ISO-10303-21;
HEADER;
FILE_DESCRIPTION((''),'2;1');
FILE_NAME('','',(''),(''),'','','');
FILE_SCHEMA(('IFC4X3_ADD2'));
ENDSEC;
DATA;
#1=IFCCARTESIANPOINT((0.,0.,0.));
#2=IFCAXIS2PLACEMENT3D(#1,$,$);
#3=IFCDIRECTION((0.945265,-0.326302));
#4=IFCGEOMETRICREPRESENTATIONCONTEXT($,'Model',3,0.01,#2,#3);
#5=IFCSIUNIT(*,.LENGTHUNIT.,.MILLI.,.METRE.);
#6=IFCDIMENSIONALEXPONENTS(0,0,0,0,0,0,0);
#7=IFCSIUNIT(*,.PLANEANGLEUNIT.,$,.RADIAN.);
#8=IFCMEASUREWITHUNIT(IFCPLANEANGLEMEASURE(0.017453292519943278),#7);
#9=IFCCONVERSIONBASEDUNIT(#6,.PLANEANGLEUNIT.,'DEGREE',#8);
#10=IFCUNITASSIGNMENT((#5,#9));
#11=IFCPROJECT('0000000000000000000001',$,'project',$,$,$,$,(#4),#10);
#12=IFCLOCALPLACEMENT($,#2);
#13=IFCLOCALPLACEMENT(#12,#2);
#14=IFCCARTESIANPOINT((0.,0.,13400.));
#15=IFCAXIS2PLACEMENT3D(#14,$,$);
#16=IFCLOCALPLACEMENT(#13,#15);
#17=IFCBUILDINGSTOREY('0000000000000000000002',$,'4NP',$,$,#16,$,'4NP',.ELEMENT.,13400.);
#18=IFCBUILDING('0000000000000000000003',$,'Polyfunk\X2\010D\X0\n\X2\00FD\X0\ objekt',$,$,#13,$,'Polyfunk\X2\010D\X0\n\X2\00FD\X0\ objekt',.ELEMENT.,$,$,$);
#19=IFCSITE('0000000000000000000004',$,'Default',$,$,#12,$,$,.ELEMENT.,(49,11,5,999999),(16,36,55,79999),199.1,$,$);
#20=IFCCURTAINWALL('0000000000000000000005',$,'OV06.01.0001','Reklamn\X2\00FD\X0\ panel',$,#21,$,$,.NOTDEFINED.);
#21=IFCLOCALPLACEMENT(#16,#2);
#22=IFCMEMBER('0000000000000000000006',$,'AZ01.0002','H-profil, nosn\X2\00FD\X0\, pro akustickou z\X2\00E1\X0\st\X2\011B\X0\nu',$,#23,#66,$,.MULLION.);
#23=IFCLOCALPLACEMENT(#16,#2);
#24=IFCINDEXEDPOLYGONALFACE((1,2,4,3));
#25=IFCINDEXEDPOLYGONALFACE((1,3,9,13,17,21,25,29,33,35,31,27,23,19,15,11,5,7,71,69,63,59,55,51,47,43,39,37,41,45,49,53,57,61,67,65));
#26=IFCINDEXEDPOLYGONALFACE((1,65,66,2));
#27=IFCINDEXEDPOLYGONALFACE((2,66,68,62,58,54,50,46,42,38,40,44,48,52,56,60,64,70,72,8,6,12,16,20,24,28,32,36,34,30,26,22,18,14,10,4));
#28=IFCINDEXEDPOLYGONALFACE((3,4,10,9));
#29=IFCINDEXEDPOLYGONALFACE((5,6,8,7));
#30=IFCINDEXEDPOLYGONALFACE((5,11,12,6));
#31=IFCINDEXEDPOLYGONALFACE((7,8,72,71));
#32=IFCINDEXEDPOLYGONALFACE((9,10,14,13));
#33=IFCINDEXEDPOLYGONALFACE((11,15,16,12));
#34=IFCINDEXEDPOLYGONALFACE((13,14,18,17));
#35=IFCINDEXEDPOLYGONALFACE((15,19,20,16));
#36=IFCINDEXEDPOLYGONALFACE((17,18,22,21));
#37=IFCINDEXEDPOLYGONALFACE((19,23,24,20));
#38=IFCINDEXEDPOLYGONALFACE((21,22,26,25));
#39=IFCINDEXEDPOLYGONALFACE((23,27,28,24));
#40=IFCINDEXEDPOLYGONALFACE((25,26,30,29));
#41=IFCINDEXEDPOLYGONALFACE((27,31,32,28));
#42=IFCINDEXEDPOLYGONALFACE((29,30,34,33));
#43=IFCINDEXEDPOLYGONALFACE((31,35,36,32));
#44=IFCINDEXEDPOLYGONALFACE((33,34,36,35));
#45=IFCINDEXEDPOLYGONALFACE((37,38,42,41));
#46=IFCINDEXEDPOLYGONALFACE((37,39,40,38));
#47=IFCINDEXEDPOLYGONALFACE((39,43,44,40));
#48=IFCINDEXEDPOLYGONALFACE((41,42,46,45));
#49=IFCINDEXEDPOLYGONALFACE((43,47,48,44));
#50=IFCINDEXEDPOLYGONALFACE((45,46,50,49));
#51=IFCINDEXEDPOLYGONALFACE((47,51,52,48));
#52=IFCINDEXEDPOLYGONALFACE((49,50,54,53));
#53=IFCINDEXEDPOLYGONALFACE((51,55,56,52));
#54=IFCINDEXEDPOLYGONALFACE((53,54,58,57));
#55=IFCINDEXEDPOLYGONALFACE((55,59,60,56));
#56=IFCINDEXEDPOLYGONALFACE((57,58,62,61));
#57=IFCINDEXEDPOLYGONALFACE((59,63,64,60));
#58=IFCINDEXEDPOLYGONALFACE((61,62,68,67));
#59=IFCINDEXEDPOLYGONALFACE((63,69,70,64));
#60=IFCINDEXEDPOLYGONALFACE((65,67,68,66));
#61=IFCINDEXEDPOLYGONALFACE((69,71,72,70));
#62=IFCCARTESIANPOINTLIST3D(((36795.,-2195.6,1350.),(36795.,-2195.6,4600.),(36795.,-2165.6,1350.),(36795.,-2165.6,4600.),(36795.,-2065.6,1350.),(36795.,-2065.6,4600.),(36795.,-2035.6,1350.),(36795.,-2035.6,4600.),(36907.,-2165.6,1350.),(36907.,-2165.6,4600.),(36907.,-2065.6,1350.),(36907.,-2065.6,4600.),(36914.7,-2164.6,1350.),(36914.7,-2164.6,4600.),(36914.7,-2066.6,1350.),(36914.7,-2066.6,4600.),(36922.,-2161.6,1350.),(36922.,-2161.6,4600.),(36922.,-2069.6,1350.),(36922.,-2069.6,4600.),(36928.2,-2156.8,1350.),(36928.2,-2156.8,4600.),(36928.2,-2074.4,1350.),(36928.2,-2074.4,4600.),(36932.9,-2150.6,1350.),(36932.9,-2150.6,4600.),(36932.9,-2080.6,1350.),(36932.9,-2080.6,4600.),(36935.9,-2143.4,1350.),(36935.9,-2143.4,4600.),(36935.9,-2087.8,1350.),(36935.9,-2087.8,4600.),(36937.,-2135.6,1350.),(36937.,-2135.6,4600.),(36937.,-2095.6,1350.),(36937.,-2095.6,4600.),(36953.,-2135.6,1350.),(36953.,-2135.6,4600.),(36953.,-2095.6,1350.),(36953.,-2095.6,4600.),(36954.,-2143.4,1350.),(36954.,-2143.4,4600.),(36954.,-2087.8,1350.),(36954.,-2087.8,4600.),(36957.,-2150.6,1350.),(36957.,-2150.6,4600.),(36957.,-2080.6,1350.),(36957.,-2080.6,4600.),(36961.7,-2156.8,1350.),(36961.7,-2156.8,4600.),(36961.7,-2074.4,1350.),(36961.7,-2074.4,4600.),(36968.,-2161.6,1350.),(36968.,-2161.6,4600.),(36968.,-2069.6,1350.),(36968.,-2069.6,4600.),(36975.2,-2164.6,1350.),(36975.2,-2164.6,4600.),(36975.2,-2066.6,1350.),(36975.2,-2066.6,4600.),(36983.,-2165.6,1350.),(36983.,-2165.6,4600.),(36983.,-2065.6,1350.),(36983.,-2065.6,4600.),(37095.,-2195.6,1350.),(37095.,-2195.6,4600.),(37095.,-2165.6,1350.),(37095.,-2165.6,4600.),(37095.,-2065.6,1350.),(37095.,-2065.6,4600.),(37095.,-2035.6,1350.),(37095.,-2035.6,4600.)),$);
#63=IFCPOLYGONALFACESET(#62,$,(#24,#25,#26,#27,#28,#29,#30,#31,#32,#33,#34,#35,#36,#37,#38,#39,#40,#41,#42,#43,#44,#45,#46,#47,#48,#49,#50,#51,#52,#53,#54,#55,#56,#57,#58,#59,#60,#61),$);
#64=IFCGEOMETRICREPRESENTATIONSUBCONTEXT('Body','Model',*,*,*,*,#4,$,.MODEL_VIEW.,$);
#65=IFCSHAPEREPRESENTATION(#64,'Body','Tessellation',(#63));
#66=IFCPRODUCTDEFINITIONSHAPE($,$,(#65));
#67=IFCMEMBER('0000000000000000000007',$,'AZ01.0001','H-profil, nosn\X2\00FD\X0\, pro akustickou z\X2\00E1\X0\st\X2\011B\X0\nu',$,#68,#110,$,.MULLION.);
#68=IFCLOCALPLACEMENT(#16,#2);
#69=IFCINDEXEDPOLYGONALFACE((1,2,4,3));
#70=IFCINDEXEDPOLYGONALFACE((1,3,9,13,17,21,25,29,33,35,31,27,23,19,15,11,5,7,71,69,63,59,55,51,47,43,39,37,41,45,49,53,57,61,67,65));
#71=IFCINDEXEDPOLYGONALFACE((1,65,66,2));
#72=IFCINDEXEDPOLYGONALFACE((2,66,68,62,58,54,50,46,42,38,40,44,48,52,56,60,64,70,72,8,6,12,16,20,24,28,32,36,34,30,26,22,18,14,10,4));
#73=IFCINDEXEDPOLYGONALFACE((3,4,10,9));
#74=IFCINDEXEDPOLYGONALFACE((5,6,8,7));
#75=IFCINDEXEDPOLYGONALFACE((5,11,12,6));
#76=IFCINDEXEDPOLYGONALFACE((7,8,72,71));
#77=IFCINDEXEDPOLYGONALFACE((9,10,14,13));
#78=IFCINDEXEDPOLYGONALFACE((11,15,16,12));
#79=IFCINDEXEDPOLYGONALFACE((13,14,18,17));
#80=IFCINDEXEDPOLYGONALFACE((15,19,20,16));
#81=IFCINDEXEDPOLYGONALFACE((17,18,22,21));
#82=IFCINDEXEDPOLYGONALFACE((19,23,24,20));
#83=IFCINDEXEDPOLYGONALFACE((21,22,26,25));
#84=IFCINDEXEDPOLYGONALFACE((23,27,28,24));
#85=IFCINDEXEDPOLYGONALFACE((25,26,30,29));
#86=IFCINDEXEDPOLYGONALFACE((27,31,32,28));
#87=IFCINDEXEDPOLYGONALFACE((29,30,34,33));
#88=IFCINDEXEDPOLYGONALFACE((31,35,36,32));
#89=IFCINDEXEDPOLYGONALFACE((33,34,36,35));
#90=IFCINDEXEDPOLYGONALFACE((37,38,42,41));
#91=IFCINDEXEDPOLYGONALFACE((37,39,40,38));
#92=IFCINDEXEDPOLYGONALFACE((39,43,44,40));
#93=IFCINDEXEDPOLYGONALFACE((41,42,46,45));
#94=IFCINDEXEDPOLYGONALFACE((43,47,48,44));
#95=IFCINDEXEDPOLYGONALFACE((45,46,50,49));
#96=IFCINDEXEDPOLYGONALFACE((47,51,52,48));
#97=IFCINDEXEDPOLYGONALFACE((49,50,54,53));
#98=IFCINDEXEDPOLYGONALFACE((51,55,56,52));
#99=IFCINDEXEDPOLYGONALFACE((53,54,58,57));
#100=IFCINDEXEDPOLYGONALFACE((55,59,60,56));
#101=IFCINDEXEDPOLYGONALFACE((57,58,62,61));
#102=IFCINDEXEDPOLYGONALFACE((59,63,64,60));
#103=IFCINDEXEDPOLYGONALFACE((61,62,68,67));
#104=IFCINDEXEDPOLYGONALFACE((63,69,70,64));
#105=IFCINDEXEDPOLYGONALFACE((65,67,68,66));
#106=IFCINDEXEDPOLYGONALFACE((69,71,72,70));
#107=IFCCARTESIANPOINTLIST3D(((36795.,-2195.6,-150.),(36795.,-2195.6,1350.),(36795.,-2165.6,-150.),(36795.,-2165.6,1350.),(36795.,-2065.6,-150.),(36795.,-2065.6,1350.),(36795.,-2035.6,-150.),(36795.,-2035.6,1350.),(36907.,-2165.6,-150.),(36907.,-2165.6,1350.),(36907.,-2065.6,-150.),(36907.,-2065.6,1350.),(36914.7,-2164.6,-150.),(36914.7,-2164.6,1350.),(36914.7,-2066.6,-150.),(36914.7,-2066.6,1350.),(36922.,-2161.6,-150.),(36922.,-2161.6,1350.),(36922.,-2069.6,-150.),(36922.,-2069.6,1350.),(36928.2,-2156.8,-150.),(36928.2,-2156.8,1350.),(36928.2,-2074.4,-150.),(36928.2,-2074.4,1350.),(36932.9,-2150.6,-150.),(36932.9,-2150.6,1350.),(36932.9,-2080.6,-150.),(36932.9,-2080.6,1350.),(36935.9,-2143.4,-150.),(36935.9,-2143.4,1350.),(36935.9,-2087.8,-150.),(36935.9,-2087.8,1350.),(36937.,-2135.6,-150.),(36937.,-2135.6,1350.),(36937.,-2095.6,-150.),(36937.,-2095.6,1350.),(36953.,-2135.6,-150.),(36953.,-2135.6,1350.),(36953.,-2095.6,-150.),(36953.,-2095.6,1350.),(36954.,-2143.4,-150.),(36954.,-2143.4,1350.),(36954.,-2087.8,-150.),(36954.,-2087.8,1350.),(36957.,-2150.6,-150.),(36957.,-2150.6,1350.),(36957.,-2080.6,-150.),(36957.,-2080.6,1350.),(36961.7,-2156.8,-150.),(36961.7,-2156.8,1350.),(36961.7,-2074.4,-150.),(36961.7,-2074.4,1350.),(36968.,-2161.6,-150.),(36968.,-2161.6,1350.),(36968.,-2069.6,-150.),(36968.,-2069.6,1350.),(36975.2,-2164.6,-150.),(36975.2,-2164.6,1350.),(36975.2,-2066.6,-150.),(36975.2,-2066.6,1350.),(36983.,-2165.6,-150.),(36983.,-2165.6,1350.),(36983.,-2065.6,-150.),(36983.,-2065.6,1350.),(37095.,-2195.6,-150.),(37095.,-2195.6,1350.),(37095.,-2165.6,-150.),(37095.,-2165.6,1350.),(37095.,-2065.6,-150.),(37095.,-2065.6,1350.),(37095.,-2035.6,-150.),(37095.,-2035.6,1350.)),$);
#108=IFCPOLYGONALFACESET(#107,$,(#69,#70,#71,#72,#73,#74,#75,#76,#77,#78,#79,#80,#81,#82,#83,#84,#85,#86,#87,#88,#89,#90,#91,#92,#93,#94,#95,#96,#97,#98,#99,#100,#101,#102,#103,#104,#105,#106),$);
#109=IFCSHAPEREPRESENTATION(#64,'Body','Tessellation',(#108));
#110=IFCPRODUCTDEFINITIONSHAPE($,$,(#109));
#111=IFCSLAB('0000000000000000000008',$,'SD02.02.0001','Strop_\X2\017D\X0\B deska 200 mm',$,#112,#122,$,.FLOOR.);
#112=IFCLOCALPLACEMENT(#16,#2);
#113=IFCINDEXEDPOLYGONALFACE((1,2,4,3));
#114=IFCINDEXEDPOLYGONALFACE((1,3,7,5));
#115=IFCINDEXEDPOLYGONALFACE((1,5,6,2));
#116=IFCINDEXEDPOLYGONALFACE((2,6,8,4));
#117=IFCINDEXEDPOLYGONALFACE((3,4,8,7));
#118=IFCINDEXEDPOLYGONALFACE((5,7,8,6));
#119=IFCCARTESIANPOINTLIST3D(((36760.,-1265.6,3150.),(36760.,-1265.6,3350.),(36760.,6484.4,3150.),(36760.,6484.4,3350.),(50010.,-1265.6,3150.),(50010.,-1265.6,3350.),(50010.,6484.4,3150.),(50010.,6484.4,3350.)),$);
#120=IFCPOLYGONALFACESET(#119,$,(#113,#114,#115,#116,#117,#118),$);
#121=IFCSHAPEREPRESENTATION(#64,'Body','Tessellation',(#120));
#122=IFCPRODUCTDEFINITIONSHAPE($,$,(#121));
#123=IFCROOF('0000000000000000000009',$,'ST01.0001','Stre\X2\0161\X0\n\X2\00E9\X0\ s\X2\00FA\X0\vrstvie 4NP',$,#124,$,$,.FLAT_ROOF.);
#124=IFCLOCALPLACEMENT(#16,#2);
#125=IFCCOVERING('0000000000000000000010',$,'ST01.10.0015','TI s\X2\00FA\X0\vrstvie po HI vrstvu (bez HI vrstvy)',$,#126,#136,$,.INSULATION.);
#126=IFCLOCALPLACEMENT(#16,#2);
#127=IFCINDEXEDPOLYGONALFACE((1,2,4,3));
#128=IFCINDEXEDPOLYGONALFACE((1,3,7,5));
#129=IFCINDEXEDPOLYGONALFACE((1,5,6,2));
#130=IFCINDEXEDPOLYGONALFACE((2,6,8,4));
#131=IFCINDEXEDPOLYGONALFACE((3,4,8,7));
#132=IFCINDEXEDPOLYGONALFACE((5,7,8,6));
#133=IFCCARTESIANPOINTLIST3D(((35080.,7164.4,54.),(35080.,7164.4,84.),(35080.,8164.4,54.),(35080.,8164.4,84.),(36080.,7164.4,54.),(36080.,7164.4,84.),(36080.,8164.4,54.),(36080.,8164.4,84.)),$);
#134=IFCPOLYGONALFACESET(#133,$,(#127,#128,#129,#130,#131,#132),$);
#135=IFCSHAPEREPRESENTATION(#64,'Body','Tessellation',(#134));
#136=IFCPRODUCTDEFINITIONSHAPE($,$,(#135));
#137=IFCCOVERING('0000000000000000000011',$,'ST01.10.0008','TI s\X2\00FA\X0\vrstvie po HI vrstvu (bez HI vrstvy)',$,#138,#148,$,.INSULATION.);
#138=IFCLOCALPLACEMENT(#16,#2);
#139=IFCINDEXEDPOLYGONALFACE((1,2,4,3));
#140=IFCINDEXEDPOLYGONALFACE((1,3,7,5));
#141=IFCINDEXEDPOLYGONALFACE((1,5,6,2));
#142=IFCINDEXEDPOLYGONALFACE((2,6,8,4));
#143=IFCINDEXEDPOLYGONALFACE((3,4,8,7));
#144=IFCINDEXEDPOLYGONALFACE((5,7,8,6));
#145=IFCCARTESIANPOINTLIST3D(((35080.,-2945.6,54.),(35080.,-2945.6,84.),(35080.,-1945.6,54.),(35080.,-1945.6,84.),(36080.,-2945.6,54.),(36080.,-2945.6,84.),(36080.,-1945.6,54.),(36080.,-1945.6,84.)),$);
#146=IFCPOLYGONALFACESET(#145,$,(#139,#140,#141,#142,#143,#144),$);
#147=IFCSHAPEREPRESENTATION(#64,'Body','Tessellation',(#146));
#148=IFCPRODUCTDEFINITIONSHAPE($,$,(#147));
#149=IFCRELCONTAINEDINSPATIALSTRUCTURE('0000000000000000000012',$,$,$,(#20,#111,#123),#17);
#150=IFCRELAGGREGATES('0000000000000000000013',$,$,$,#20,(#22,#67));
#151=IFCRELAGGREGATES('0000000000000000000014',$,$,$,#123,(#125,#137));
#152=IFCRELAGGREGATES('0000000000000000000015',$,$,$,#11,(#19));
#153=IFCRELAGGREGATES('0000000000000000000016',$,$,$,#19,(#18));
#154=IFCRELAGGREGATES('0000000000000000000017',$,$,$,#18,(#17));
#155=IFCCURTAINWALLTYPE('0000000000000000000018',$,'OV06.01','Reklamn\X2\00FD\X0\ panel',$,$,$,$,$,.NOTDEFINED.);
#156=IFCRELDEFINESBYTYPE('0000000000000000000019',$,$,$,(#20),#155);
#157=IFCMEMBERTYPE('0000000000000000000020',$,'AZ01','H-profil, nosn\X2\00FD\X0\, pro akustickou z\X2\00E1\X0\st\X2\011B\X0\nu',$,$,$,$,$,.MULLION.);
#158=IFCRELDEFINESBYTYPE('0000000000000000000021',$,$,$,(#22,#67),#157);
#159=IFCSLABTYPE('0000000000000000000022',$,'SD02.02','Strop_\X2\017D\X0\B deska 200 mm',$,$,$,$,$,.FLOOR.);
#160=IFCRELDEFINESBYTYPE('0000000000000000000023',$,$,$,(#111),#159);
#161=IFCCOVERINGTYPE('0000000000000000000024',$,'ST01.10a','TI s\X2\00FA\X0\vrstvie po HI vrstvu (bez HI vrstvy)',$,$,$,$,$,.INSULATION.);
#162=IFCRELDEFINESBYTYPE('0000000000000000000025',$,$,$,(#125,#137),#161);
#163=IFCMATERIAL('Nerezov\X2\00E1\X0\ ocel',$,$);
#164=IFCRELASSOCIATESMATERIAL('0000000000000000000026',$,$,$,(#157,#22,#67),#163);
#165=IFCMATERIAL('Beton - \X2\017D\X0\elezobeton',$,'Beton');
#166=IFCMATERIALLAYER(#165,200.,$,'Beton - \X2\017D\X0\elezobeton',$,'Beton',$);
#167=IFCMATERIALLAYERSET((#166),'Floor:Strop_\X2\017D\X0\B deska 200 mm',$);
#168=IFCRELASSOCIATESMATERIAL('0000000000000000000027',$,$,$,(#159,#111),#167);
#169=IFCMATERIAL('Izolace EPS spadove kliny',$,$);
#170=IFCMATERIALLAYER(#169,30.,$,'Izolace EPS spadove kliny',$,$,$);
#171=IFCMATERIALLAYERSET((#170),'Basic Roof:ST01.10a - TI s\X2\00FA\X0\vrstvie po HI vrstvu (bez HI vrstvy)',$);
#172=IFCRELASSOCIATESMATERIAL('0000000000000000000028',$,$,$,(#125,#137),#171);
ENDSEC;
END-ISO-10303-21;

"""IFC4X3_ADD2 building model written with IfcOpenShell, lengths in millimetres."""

from ifc_helpers import new_model, entity, si_unit, converted_unit, direction, frame, frame_2d, origin, place, context, subcontext, project, spatial, polyline, circle_curve, parameter, trimmed, segment, composite_curve, rectangle, outline, extrude, source, transform, mapped, material, layer, layer_set, layer_usage, material_profile, profile_set, profile_usage, type_object, type_shapes, element, aggregate, save


model = new_model("IFC4X3_ADD2")

# Units and contexts
model_context = context("Model", 3, precision=0.01, world=origin(), true_north=direction((0.945265, -0.326302)))
body_context = subcontext(model_context, "Body", "Model", "MODEL_VIEW")
ifc_project = project(units=[si_unit("LENGTHUNIT", "METRE", prefix="MILLI"), converted_unit("PLANEANGLEUNIT", "DEGREE", entity("IfcPlaneAngleMeasure", 0.017453292519943278), si_unit("PLANEANGLEUNIT", "RADIAN"), dimensions=[0, 0, 0, 0, 0, 0, 0])], contexts=[model_context])

# Site, building, storey
site_placement = place(None, origin())
site = spatial("IfcSite", under=ifc_project, at=site_placement, Name="Default", CompositionType="ELEMENT", RefLatitude=(49, 11, 5, 999999), RefLongitude=(16, 36, 55, 79999), RefElevation=199.1)
building_placement = place(site_placement, origin())
building = spatial("IfcBuilding", under=site, at=building_placement, Name="Polyfunkčný objekt", LongName="Polyfunkčný objekt", CompositionType="ELEMENT")
storey_placement = place(building_placement, frame((0.0, 0.0, 13400.0)))
storey = spatial("IfcBuildingStorey", under=building, at=storey_placement, Name="4NP", LongName="4NP", CompositionType="ELEMENT", Elevation=13400.0)

# Curtain wall, members
curtain_wall_type = type_object("IfcCurtainWallType", Name="OV06.01", Description="Reklamný panel", PredefinedType="NOTDEFINED")
curtain_wall_placement = place(storey_placement, frame((0.0, 0.0, -13400.0)))
curtain_wall = element("IfcCurtainWall", 1, at=curtain_wall_placement, inside=storey, type_object=curtain_wall_type, Name="OV06.01.0001", Description="Reklamný panel", PredefinedType="NOTDEFINED")
ifc_material_1 = material(Name="Nerezová ocel")
ifc_material_profile = material_profile(ifc_material_1, outline(composite_curve([segment(polyline([(50.0, -150.0), (80.0, -150.0)]), True, "CONTINUOUS"), segment(polyline([(80.0, -150.0), (80.0, 150.0)]), True, "CONTINUOUS"), segment(polyline([(80.0, 150.0), (50.0, 150.0)]), True, "CONTINUOUS"), segment(polyline([(50.0, 150.0), (50.0, 38.0)]), True, "CONTINUOUS"), segment(trimmed(circle_curve(frame_2d((20.0, 38.0), x_axis=(0.0, 1.0)), 30.0), [parameter(180.0)], [parameter(270.0)], True, "PARAMETER"), False, "CONTINUOUS"), segment(polyline([(20.0, 8.0), (-20.0, 8.0)]), True, "CONTINUOUS"), segment(trimmed(circle_curve(frame_2d((-20.0, 38.0), x_axis=(0.0, 1.0)), 30.0), [parameter(90.0)], [parameter(180.0)], True, "PARAMETER"), False, "CONTINUOUS"), segment(polyline([(-50.0, 38.0), (-50.0, 150.0)]), True, "CONTINUOUS"), segment(polyline([(-50.0, 150.0), (-80.0, 150.0)]), True, "CONTINUOUS"), segment(polyline([(-80.0, 150.0), (-80.0, -150.0)]), True, "CONTINUOUS"), segment(polyline([(-80.0, -150.0), (-50.0, -150.0)]), True, "CONTINUOUS"), segment(polyline([(-50.0, -150.0), (-50.0, -38.0)]), True, "CONTINUOUS"), segment(trimmed(circle_curve(frame_2d((-20.0, -38.0), x_axis=(0.0, 1.0)), 30.0), [parameter(0.0)], [parameter(90.0)], True, "PARAMETER"), False, "CONTINUOUS"), segment(polyline([(-20.0, -8.0), (20.0, -8.0)]), True, "CONTINUOUS"), segment(trimmed(circle_curve(frame_2d((20.0, -38.0), x_axis=(0.0, 1.0)), 30.0), [parameter(270.0)], [parameter(0.0)], True, "PARAMETER"), False, "CONTINUOUS"), segment(polyline([(50.0, -38.0), (50.0, -150.0)]), True, "CONTINUOUS")], self_intersect=False)), Name="Profil zástena")
ifc_profile_set = profile_set([ifc_material_profile], Name="Profil zástena")
ifc_profile_usage = profile_usage(ifc_profile_set)
member_type = type_object("IfcMemberType", Name="AZ01", Description="H-profil, nosný, pro akustickou zástěnu", PredefinedType="MULLION", material=ifc_profile_set)
shared_shape_1 = source(origin(), body_context, "Body", "SweptSolid", [
    extrude(outline(composite_curve([segment(polyline([(50.0, -150.0), (80.0, -150.0)]), True, "CONTINUOUS"), segment(polyline([(80.0, -150.0), (80.0, 150.0)]), True, "CONTINUOUS"), segment(polyline([(80.0, 150.0), (50.0, 150.0)]), True, "CONTINUOUS"), segment(polyline([(50.0, 150.0), (50.0, 38.0)]), True, "CONTINUOUS"), segment(trimmed(circle_curve(frame_2d((20.0, 38.0), x_axis=(0.0, 1.0)), 30.0), [parameter(180.0)], [parameter(270.0)], True, "PARAMETER"), False, "CONTINUOUS"), segment(polyline([(20.0, 8.0), (-20.0, 8.0)]), True, "CONTINUOUS"), segment(trimmed(circle_curve(frame_2d((-20.0, 38.0), x_axis=(0.0, 1.0)), 30.0), [parameter(90.0)], [parameter(180.0)], True, "PARAMETER"), False, "CONTINUOUS"), segment(polyline([(-50.0, 38.0), (-50.0, 150.0)]), True, "CONTINUOUS"), segment(polyline([(-50.0, 150.0), (-80.0, 150.0)]), True, "CONTINUOUS"), segment(polyline([(-80.0, 150.0), (-80.0, -150.0)]), True, "CONTINUOUS"), segment(polyline([(-80.0, -150.0), (-50.0, -150.0)]), True, "CONTINUOUS"), segment(polyline([(-50.0, -150.0), (-50.0, -38.0)]), True, "CONTINUOUS"), segment(trimmed(circle_curve(frame_2d((-20.0, -38.0), x_axis=(0.0, 1.0)), 30.0), [parameter(0.0)], [parameter(90.0)], True, "PARAMETER"), False, "CONTINUOUS"), segment(polyline([(-20.0, -8.0), (20.0, -8.0)]), True, "CONTINUOUS"), segment(trimmed(circle_curve(frame_2d((20.0, -38.0), x_axis=(0.0, 1.0)), 30.0), [parameter(270.0)], [parameter(0.0)], True, "PARAMETER"), False, "CONTINUOUS"), segment(polyline([(50.0, -38.0), (50.0, -150.0)]), True, "CONTINUOUS")], self_intersect=False)), frame((-150.0, 0.0, -3250.0), z_axis=(0.0, 0.0, 1.0), x_axis=(0.0, 1.0, 0.0)), (0.0, 0.0, 1.0), 3250.0),
])
member_1_placement = place(curtain_wall_placement, frame((36795.0, -2115.6, 18000.0), z_axis=(0.0, 0.0, 1.0), x_axis=(-1.0, 0.0, 0.0)))
member_1 = element("IfcMember", 2, at=member_1_placement, type_object=member_type, material=ifc_profile_usage, Name="AZ01.0002", Description="H-profil, nosný, pro akustickou zástěnu", PredefinedType="MULLION", context=body_context, shape_type="MappedRepresentation", body=[
    mapped(shared_shape_1, transform((0.0, 0.0, 0.0), scale=1.0)),
])
shared_shape_2 = source(origin(), body_context, "Body", "SweptSolid", [
    extrude(outline(composite_curve([segment(polyline([(50.0, -150.0), (80.0, -150.0)]), True, "CONTINUOUS"), segment(polyline([(80.0, -150.0), (80.0, 150.0)]), True, "CONTINUOUS"), segment(polyline([(80.0, 150.0), (50.0, 150.0)]), True, "CONTINUOUS"), segment(polyline([(50.0, 150.0), (50.0, 38.0)]), True, "CONTINUOUS"), segment(trimmed(circle_curve(frame_2d((20.0, 38.0), x_axis=(0.0, 1.0)), 30.0), [parameter(180.0)], [parameter(270.0)], True, "PARAMETER"), False, "CONTINUOUS"), segment(polyline([(20.0, 8.0), (-20.0, 8.0)]), True, "CONTINUOUS"), segment(trimmed(circle_curve(frame_2d((-20.0, 38.0), x_axis=(0.0, 1.0)), 30.0), [parameter(90.0)], [parameter(180.0)], True, "PARAMETER"), False, "CONTINUOUS"), segment(polyline([(-50.0, 38.0), (-50.0, 150.0)]), True, "CONTINUOUS"), segment(polyline([(-50.0, 150.0), (-80.0, 150.0)]), True, "CONTINUOUS"), segment(polyline([(-80.0, 150.0), (-80.0, -150.0)]), True, "CONTINUOUS"), segment(polyline([(-80.0, -150.0), (-50.0, -150.0)]), True, "CONTINUOUS"), segment(polyline([(-50.0, -150.0), (-50.0, -38.0)]), True, "CONTINUOUS"), segment(trimmed(circle_curve(frame_2d((-20.0, -38.0), x_axis=(0.0, 1.0)), 30.0), [parameter(0.0)], [parameter(90.0)], True, "PARAMETER"), False, "CONTINUOUS"), segment(polyline([(-20.0, -8.0), (20.0, -8.0)]), True, "CONTINUOUS"), segment(trimmed(circle_curve(frame_2d((20.0, -38.0), x_axis=(0.0, 1.0)), 30.0), [parameter(270.0)], [parameter(0.0)], True, "PARAMETER"), False, "CONTINUOUS"), segment(polyline([(50.0, -38.0), (50.0, -150.0)]), True, "CONTINUOUS")], self_intersect=False)), frame((-150.0, 0.0, -1500.0), z_axis=(0.0, 0.0, 1.0), x_axis=(0.0, 1.0, 0.0)), (0.0, 0.0, 1.0), 1500.0),
])
type_shapes(member_type, [shared_shape_1, shared_shape_2])
member_2_placement = place(curtain_wall_placement, frame((36795.0, -2115.6, 14750.0), z_axis=(0.0, 0.0, 1.0), x_axis=(-1.0, 0.0, 0.0)))
member_2 = element("IfcMember", 3, at=member_2_placement, type_object=member_type, material=ifc_profile_usage, Name="AZ01.0001", Description="H-profil, nosný, pro akustickou zástěnu", PredefinedType="MULLION", context=body_context, shape_type="MappedRepresentation", body=[
    mapped(shared_shape_2, transform((0.0, 0.0, 0.0), scale=1.0)),
])
aggregate(curtain_wall, [member_1, member_2])

# Slab
ifc_material_2 = material(Name="Beton - Železobeton", Category="Beton")
ifc_layer_1 = layer(ifc_material_2, 200.0, Name="Beton - Železobeton", Category="Beton")
ifc_layer_set_1 = layer_set([ifc_layer_1], Name="Floor:Strop_ŽB deska 200 mm")
ifc_layer_usage_1 = layer_usage(ifc_layer_set_1, "AXIS3", "POSITIVE", 0.0)
slab_type = type_object("IfcSlabType", Name="SD02.02", Description="Strop_ŽB deska 200 mm", PredefinedType="FLOOR", material=ifc_layer_set_1)
slab_placement = place(storey_placement, origin())
element("IfcSlab", 4, at=slab_placement, inside=storey, type_object=slab_type, material=ifc_layer_usage_1, Name="SD02.02.0001", Description="Strop_ŽB deska 200 mm", PredefinedType="FLOOR", context=body_context, shape_type="SweptSolid", body=[
    extrude(rectangle(XDim=7750.0, YDim=13250.0, at=frame_2d((0.0, 0.0), x_axis=(1.0, 0.0))), frame((43385.0, 2609.4, 3350.0), z_axis=(0.0, 0.0, -1.0), x_axis=(0.0, 1.0, 0.0)), (0.0, 0.0, 1.0), 200.0),
])

# Roof, coverings
roof = element("IfcRoof", 5, inside=storey, Name="ST01.0001", Description="Strešné súvrstvie 4NP", PredefinedType="FLAT_ROOF")
ifc_material_3 = material(Name="Izolace EPS spadove kliny")
ifc_layer_2 = layer(ifc_material_3, 30.0, Name="Izolace EPS spadove kliny")
ifc_layer_set_2 = layer_set([ifc_layer_2], Name="Basic Roof:ST01.10a - TI súvrstvie po HI vrstvu (bez HI vrstvy)")
covering_type_1 = type_object("IfcCoveringType", Name="ST01.10a", Description="TI súvrstvie po HI vrstvu (bez HI vrstvy)", PredefinedType="INSULATION")
placement_1 = place(storey_placement, frame((35080.0, 7164.4, 54.0)))
covering_1_placement = place(placement_1, origin())
covering_1 = element("IfcCovering", 6, at=covering_1_placement, type_object=covering_type_1, material=ifc_layer_set_2, Name="ST01.10.0015", Description="TI súvrstvie po HI vrstvu (bez HI vrstvy)", PredefinedType="INSULATION", context=body_context, shape_type="SweptSolid", body=[
    extrude(rectangle(XDim=1000.0, YDim=1000.0, at=frame_2d((0.0, 0.0), x_axis=(1.0, 0.0))), frame((500.0, 500.0, 0.0)), (0.0, 0.0, 1.0), 30.0),
])
covering_2_placement = place(storey_placement, frame((35080.0, -2945.6, 54.0)))
covering_2 = element("IfcCovering", 7, at=covering_2_placement, type_object=covering_type_1, material=ifc_layer_set_2, Name="ST01.10.0008", Description="TI súvrstvie po HI vrstvu (bez HI vrstvy)", PredefinedType="INSULATION", context=body_context, shape_type="SweptSolid", body=[
    extrude(rectangle(XDim=1000.0, YDim=1000.0, at=frame_2d((0.0, 0.0), x_axis=(1.0, 0.0))), frame((500.0, 500.0, 0.0), z_axis=(0.0, 0.0, 1.0), x_axis=(0.0, 1.0, 0.0)), (0.0, 0.0, 1.0), 30.0),
])
aggregate(roof, [covering_1, covering_2])

save(model, "model.ifc")
